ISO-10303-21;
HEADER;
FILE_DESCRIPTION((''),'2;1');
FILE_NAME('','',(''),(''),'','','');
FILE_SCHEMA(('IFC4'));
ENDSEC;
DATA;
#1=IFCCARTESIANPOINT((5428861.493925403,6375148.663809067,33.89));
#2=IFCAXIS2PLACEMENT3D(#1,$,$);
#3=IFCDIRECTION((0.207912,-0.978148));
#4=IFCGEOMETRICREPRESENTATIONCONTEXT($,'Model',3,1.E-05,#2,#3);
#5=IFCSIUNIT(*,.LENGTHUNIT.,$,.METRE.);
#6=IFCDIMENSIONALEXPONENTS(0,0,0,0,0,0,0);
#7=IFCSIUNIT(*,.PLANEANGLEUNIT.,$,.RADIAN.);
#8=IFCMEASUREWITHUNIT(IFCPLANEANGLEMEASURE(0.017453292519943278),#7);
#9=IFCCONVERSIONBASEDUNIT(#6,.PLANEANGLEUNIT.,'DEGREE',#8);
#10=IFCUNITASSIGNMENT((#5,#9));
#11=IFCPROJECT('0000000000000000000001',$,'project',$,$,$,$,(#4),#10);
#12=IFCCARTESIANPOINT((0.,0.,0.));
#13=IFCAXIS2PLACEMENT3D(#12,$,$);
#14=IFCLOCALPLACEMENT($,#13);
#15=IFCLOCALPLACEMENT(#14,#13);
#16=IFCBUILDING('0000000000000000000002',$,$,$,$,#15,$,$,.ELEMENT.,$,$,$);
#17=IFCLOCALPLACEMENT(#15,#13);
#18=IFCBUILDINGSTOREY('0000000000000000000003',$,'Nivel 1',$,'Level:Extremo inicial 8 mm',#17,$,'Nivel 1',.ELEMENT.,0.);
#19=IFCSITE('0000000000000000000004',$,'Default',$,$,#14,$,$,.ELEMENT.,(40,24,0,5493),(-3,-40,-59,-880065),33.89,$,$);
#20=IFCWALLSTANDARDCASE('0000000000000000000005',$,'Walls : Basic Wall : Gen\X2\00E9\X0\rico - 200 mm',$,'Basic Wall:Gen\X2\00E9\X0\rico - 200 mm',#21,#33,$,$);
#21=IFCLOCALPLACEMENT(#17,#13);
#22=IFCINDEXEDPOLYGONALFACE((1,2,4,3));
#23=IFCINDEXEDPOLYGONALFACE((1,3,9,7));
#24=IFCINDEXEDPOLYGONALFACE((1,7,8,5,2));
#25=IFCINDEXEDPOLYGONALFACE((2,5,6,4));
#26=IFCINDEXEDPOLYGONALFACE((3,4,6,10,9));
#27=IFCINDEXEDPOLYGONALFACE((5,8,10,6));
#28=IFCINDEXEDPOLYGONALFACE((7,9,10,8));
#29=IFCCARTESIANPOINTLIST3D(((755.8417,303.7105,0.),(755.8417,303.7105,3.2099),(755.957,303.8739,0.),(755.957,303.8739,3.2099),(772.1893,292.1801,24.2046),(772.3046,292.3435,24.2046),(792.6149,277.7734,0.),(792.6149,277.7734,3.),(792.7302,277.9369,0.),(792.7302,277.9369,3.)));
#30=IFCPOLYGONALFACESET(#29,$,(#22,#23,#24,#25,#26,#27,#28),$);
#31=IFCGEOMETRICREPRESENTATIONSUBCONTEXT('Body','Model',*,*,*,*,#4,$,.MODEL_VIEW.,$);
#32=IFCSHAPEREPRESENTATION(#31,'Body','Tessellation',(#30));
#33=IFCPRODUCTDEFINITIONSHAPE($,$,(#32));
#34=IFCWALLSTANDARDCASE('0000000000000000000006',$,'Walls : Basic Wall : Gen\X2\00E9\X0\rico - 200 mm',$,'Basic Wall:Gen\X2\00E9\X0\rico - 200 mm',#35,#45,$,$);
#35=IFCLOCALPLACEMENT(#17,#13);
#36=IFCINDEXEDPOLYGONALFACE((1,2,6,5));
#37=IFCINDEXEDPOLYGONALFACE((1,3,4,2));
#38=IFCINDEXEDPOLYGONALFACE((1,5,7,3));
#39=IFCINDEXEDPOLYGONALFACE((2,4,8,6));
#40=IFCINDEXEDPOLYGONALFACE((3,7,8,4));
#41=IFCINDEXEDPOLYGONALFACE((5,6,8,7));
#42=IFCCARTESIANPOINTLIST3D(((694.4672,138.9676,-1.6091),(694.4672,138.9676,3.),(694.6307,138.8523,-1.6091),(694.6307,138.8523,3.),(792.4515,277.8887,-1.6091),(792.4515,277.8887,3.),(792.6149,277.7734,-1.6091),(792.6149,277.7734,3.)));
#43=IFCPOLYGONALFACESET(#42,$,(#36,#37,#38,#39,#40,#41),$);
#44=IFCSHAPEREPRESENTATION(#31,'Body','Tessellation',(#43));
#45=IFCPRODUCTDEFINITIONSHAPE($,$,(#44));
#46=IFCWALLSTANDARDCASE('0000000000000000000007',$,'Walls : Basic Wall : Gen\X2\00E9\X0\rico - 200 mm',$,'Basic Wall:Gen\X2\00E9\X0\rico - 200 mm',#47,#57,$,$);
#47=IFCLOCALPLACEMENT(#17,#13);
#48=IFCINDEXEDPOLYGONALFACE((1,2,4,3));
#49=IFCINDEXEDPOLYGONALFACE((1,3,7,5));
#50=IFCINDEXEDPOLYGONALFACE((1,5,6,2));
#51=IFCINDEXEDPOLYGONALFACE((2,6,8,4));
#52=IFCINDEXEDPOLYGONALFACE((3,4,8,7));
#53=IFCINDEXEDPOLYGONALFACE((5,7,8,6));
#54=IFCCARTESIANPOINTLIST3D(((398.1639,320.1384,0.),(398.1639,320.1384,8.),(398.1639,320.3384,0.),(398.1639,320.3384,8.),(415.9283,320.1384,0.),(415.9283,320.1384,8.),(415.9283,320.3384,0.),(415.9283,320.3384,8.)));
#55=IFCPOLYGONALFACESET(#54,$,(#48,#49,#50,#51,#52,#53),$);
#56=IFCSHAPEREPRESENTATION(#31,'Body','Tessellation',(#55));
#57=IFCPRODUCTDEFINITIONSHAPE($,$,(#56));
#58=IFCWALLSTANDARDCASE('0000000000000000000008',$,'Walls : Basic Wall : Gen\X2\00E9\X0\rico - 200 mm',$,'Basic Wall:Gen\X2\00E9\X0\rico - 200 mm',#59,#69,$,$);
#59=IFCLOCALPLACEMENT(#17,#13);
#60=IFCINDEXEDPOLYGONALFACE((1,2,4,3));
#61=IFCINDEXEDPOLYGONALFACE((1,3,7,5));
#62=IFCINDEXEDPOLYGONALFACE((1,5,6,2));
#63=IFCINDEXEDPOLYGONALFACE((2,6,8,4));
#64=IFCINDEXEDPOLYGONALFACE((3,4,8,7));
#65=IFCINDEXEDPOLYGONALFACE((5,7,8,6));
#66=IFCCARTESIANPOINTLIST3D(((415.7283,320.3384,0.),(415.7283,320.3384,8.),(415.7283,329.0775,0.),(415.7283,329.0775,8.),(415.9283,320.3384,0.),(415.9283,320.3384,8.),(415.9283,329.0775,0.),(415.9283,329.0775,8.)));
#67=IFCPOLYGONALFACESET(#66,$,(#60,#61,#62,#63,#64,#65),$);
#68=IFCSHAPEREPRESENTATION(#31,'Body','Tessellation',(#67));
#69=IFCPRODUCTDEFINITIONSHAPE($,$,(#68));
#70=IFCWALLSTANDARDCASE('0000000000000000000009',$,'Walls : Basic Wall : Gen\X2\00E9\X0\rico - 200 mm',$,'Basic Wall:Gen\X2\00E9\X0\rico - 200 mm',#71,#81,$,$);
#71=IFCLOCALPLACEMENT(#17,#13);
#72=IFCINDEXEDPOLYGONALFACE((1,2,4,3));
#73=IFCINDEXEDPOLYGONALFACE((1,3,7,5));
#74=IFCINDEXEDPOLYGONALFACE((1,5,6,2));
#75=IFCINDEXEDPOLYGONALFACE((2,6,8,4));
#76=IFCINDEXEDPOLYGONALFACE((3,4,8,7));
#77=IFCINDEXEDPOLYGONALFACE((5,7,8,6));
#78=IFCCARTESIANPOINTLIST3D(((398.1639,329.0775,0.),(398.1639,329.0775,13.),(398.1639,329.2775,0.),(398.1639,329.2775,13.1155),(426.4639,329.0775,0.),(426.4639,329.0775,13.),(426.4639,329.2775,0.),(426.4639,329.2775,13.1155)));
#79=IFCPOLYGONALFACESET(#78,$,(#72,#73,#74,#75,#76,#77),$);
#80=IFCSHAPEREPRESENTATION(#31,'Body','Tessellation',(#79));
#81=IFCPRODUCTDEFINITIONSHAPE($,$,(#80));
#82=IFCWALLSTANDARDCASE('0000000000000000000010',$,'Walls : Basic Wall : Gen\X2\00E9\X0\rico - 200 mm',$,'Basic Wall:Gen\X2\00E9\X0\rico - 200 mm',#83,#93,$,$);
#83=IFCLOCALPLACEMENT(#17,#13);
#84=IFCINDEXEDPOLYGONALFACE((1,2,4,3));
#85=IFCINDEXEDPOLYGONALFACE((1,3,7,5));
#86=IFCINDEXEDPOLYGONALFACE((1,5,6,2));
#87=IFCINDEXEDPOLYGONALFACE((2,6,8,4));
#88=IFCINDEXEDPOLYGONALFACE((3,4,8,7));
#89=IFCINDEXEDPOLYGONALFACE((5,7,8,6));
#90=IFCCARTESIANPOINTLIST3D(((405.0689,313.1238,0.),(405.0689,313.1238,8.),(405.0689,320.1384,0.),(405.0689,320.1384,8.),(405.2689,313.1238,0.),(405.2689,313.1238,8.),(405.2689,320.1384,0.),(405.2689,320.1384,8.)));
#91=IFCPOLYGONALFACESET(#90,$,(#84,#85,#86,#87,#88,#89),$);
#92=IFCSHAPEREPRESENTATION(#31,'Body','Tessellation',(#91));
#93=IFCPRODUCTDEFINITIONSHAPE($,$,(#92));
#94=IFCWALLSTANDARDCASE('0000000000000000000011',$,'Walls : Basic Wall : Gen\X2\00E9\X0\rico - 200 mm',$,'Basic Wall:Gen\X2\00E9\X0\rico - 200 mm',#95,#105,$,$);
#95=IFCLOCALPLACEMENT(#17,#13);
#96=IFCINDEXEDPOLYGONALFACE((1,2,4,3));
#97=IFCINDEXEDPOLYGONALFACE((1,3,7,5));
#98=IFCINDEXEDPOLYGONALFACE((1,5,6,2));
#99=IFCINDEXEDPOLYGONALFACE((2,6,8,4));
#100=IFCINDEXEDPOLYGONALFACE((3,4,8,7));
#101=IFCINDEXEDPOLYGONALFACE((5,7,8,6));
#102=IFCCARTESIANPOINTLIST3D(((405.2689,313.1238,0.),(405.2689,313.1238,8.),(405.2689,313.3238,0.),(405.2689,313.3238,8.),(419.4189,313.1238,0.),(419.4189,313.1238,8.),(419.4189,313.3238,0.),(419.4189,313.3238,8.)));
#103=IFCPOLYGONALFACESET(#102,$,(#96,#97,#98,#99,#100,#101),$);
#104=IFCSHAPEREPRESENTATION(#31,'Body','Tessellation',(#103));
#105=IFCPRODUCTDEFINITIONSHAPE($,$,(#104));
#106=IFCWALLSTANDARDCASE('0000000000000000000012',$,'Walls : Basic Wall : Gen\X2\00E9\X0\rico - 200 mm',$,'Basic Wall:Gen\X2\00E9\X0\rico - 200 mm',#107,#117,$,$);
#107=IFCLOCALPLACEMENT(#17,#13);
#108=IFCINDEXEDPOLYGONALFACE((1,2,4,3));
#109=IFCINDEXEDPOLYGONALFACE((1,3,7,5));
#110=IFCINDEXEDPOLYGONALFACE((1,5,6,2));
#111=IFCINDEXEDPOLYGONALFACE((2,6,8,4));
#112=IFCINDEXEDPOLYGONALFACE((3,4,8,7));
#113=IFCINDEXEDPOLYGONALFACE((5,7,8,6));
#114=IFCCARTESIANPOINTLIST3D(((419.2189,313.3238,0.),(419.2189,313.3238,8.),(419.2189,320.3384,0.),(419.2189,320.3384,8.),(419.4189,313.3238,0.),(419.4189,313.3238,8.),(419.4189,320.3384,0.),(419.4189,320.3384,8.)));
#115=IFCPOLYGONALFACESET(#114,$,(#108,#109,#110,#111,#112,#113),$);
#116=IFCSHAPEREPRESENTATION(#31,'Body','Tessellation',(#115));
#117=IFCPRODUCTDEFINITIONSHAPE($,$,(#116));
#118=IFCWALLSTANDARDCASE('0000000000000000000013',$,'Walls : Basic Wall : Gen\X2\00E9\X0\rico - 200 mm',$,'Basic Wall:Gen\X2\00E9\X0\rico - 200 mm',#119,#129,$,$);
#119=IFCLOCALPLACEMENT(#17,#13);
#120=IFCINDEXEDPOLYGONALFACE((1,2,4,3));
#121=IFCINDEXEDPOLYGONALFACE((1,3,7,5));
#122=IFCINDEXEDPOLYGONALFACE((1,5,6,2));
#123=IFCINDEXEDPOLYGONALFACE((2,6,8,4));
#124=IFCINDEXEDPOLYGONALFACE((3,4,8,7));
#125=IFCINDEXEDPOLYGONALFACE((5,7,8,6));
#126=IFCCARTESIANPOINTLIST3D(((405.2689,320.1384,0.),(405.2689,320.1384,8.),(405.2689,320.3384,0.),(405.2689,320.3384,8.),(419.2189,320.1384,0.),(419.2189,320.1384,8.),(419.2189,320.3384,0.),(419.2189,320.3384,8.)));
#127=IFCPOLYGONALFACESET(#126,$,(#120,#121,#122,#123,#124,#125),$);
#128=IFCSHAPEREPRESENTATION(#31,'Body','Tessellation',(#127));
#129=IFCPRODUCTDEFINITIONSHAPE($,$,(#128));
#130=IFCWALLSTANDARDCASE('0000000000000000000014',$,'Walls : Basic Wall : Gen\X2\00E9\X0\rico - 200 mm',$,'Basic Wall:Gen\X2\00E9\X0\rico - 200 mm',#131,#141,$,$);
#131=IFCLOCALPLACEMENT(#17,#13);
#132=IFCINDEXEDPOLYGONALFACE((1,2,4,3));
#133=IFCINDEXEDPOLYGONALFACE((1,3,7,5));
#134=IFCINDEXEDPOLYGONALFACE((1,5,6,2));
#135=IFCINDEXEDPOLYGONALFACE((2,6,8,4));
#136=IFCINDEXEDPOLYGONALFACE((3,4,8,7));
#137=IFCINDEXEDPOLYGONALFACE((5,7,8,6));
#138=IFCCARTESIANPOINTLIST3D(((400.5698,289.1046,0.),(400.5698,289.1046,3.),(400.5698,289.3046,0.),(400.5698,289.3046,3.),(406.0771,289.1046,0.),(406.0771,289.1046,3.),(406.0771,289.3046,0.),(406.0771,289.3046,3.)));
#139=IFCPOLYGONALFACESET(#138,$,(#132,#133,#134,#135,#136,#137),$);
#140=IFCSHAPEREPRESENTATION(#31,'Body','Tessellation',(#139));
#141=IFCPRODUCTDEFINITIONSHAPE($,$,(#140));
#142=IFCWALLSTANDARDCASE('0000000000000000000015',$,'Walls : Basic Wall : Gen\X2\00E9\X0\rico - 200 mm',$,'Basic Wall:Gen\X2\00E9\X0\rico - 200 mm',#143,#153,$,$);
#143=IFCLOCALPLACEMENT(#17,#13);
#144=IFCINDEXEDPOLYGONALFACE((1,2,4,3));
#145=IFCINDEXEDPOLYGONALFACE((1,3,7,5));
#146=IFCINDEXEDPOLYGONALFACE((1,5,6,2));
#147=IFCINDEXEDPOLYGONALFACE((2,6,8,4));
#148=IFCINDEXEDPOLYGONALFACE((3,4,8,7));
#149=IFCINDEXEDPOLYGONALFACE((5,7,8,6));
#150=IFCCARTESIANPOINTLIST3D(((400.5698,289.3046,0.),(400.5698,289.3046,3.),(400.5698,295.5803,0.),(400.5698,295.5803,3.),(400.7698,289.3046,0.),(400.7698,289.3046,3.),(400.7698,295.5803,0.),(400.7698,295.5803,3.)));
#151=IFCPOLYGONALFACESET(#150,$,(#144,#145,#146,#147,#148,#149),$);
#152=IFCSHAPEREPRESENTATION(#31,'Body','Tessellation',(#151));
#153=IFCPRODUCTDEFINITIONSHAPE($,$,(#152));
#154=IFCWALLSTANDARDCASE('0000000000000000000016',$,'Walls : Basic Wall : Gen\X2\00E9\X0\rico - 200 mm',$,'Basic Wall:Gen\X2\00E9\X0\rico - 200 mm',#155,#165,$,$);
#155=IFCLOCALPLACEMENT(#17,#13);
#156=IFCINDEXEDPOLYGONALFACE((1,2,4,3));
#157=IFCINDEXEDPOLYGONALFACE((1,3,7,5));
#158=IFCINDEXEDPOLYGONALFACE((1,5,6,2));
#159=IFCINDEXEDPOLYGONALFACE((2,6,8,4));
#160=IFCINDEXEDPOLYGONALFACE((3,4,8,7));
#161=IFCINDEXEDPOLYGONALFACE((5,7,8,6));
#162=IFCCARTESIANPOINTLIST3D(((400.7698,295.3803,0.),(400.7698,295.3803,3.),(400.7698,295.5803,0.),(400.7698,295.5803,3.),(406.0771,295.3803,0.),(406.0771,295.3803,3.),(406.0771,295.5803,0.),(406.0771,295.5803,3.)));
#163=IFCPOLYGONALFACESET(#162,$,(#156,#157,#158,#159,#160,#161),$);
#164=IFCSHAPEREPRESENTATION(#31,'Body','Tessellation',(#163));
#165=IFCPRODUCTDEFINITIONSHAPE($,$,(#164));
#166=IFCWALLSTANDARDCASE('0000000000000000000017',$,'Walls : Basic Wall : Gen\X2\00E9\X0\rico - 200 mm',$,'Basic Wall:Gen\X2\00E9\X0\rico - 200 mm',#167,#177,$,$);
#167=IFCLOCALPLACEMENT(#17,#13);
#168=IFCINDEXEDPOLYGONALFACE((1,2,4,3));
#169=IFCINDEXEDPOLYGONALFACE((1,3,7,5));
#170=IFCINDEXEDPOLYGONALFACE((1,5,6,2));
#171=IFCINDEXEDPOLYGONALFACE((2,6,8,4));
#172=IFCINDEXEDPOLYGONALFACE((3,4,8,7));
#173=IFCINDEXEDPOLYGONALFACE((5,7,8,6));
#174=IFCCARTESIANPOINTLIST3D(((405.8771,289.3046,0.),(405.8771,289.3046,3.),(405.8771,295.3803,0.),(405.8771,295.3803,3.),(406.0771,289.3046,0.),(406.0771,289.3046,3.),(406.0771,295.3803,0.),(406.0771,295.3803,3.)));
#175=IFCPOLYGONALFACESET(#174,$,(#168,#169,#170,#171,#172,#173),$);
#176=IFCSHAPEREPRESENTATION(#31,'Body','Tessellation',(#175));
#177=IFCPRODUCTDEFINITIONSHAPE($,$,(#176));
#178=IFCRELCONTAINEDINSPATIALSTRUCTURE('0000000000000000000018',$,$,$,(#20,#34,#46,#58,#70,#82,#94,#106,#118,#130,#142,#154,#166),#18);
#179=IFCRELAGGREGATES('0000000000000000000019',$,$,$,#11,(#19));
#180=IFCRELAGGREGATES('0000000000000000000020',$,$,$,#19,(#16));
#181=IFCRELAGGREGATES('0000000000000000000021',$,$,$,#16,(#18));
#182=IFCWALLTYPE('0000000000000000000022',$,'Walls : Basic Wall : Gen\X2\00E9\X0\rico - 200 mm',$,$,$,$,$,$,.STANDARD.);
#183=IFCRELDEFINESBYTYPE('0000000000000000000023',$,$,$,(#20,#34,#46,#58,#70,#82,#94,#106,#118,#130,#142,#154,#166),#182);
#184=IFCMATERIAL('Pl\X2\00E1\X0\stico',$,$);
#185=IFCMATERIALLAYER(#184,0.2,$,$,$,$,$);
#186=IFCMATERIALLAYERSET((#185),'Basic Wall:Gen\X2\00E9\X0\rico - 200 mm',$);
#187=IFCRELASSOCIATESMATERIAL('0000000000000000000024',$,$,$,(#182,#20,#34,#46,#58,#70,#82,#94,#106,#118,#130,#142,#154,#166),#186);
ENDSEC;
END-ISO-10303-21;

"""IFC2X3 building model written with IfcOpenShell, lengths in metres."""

from ifc_helpers import new_model, entity, si_unit, converted_unit, direction, frame, frame_2d, origin, place, context, subcontext, project, spatial, polyline, rectangle, extrude, clip, bounded_halfspace, material, layer, layer_set, layer_usage, type_object, element, save


model = new_model("IFC2X3")

# Units and contexts
model_context = context("Model", 3, precision=1e-05, world=frame((5428861.493925403, 6375148.663809067, 33.89)), true_north=direction((0.207912, -0.978148)))
body_context = subcontext(model_context, "Body", "Model", "MODEL_VIEW")
ifc_project = project(units=[si_unit("LENGTHUNIT", "METRE"), converted_unit("PLANEANGLEUNIT", "DEGREE", entity("IfcPlaneAngleMeasure", 0.017453292519943278), si_unit("PLANEANGLEUNIT", "RADIAN"), dimensions=[0, 0, 0, 0, 0, 0, 0])], contexts=[model_context])

# Site, building, storey
site_placement = place(None, origin())
site = spatial("IfcSite", under=ifc_project, at=site_placement, Name="Default", CompositionType="ELEMENT", RefLatitude=(40, 24, 0, 5493), RefLongitude=(-3, -40, -59, -880065), RefElevation=33.89)
building_placement = place(site_placement, origin())
building = spatial("IfcBuilding", under=site, at=building_placement, CompositionType="ELEMENT")
storey_placement = place(building_placement, origin())
storey = spatial("IfcBuildingStorey", under=building, at=storey_placement, Name="Nivel 1", ObjectType="Level:Extremo inicial 8 mm", LongName="Nivel 1", CompositionType="ELEMENT", Elevation=0.0)

# Walls
ifc_material = material(Name="Plástico")
ifc_layer = layer(ifc_material, 0.2)
ifc_layer_set = layer_set([ifc_layer], Name="Basic Wall:Genérico - 200 mm")
ifc_layer_usage_1 = layer_usage(ifc_layer_set, "AXIS2", "NEGATIVE", 0.1)
wall_type = type_object("IfcWallType", Name="Walls : Basic Wall : Genérico - 200 mm", PredefinedType="STANDARD", material=ifc_layer_set)
wall_1_placement = place(storey_placement, frame((755.8993, 303.7922, 0.0), z_axis=(0.0, 0.0, 1.0), x_axis=(0.817183, -0.576378, 0.0)))
element("IfcWallStandardCase", 1, at=wall_1_placement, inside=storey, type_object=wall_type, material=ifc_layer_usage_1, Name="Walls : Basic Wall : Genérico - 200 mm", ObjectType="Basic Wall:Genérico - 200 mm", context=body_context, shape_type="Clipping", body=[
    clip(clip(extrude(rectangle(XDim=45.0, YDim=0.2, at=frame_2d((22.5, 0.0), x_axis=(-1.0, 0.0))), origin(), (0.0, 0.0, 1.0), 24.2046), bounded_halfspace(frame((20.0049, -0.1, 24.2046), z_axis=(0.646917, 0.0, 0.76256), x_axis=(0.0, 1.0, 0.0)), False, frame((20.0049, -0.1, 24.2046)), polyline([(0.0, 0.0), (24.9951, 0.0), (24.9951, 0.2), (0.0, 0.2), (0.0, 0.0)]))), bounded_halfspace(frame((0.0, -0.1, 3.2099), z_axis=(-0.723966, 0.0, 0.689835), x_axis=(0.0, -1.0, 0.0)), False, frame((0.0, -0.1, 3.2099)), polyline([(0.0, 0.0), (20.0049, 0.0), (20.0049, 0.2), (0.0, 0.2), (0.0, 0.0)]))),
])
ifc_layer_usage_2 = layer_usage(ifc_layer_set, "AXIS2", "NEGATIVE", 0.1)
wall_2_placement = place(storey_placement, frame((792.5332, 277.8311, -1.6091), z_axis=(0.0, 0.0, 1.0), x_axis=(-0.576378, -0.817183, 0.0)))
element("IfcWallStandardCase", 2, at=wall_2_placement, inside=storey, type_object=wall_type, material=ifc_layer_usage_2, Name="Walls : Basic Wall : Genérico - 200 mm", ObjectType="Basic Wall:Genérico - 200 mm", context=body_context, shape_type="SweptSolid", body=[
    extrude(rectangle(XDim=170.0, YDim=0.2, at=frame_2d((85.0, 0.0), x_axis=(-1.0, 0.0))), origin(), (0.0, 0.0, 1.0), 4.6091),
])
ifc_layer_usage_3 = layer_usage(ifc_layer_set, "AXIS2", "NEGATIVE", 0.1)
wall_3_placement = place(storey_placement, frame((398.1639, 320.2384, 0.0)))
element("IfcWallStandardCase", 3, at=wall_3_placement, inside=storey, type_object=wall_type, material=ifc_layer_usage_3, Name="Walls : Basic Wall : Genérico - 200 mm", ObjectType="Basic Wall:Genérico - 200 mm", context=body_context, shape_type="SweptSolid", body=[
    extrude(rectangle(XDim=17.7644, YDim=0.2, at=frame_2d((8.8822, 0.0), x_axis=(-1.0, 0.0))), origin(), (0.0, 0.0, 1.0), 8.0),
])
ifc_layer_usage_4 = layer_usage(ifc_layer_set, "AXIS2", "NEGATIVE", 0.1)
wall_4_placement = place(storey_placement, frame((415.8283, 320.3384, 0.0), z_axis=(0.0, 0.0, 1.0), x_axis=(0.0, 1.0, 0.0)))
element("IfcWallStandardCase", 4, at=wall_4_placement, inside=storey, type_object=wall_type, material=ifc_layer_usage_4, Name="Walls : Basic Wall : Genérico - 200 mm", ObjectType="Basic Wall:Genérico - 200 mm", context=body_context, shape_type="SweptSolid", body=[
    extrude(rectangle(XDim=8.7391, YDim=0.2, at=frame_2d((4.3695, 0.0), x_axis=(-1.0, 0.0))), origin(), (0.0, 0.0, 1.0), 8.0),
])
ifc_layer_usage_5 = layer_usage(ifc_layer_set, "AXIS2", "NEGATIVE", 0.1)
wall_5_placement = place(storey_placement, frame((426.4639, 329.1775, 0.0), z_axis=(0.0, 0.0, 1.0), x_axis=(-1.0, 0.0, 0.0)))
element("IfcWallStandardCase", 5, at=wall_5_placement, inside=storey, type_object=wall_type, material=ifc_layer_usage_5, Name="Walls : Basic Wall : Genérico - 200 mm", ObjectType="Basic Wall:Genérico - 200 mm", context=body_context, shape_type="Clipping", body=[
    clip(extrude(rectangle(XDim=28.3, YDim=0.2, at=frame_2d((14.15, 0.0), x_axis=(-1.0, 0.0))), origin(), (0.0, 0.0, 1.0), 13.1155), bounded_halfspace(frame((0.0, -0.1, 13.1155), z_axis=(0.0, 0.5, 0.866025), x_axis=(-1.0, 0.0, 0.0)), False, frame((0.0, -0.1, 13.1155)), polyline([(0.0, 0.0), (28.3, 0.0), (28.3, 0.2), (0.0, 0.2), (0.0, 0.0)]))),
])
ifc_layer_usage_6 = layer_usage(ifc_layer_set, "AXIS2", "NEGATIVE", 0.1)
wall_6_placement = place(storey_placement, frame((405.1689, 320.1384, 0.0), z_axis=(0.0, 0.0, 1.0), x_axis=(0.0, -1.0, 0.0)))
element("IfcWallStandardCase", 6, at=wall_6_placement, inside=storey, type_object=wall_type, material=ifc_layer_usage_6, Name="Walls : Basic Wall : Genérico - 200 mm", ObjectType="Basic Wall:Genérico - 200 mm", context=body_context, shape_type="SweptSolid", body=[
    extrude(rectangle(XDim=7.0146, YDim=0.2, at=frame_2d((3.5073, 0.0), x_axis=(-1.0, 0.0))), origin(), (0.0, 0.0, 1.0), 8.0),
])
ifc_layer_usage_7 = layer_usage(ifc_layer_set, "AXIS2", "NEGATIVE", 0.1)
wall_7_placement = place(storey_placement, frame((405.2689, 313.2238, 0.0)))
element("IfcWallStandardCase", 7, at=wall_7_placement, inside=storey, type_object=wall_type, material=ifc_layer_usage_7, Name="Walls : Basic Wall : Genérico - 200 mm", ObjectType="Basic Wall:Genérico - 200 mm", context=body_context, shape_type="SweptSolid", body=[
    extrude(rectangle(XDim=14.15, YDim=0.2, at=frame_2d((7.075, 0.0), x_axis=(-1.0, 0.0))), origin(), (0.0, 0.0, 1.0), 8.0),
])
ifc_layer_usage_8 = layer_usage(ifc_layer_set, "AXIS2", "NEGATIVE", 0.1)
wall_8_placement = place(storey_placement, frame((419.3189, 313.3238, 0.0), z_axis=(0.0, 0.0, 1.0), x_axis=(0.0, 1.0, 0.0)))
element("IfcWallStandardCase", 8, at=wall_8_placement, inside=storey, type_object=wall_type, material=ifc_layer_usage_8, Name="Walls : Basic Wall : Genérico - 200 mm", ObjectType="Basic Wall:Genérico - 200 mm", context=body_context, shape_type="SweptSolid", body=[
    extrude(rectangle(XDim=7.0146, YDim=0.2, at=frame_2d((3.5073, 0.0), x_axis=(-1.0, 0.0))), origin(), (0.0, 0.0, 1.0), 8.0),
])
ifc_layer_usage_9 = layer_usage(ifc_layer_set, "AXIS2", "NEGATIVE", 0.1)
wall_9_placement = place(storey_placement, frame((419.2189, 320.2384, 0.0), z_axis=(0.0, 0.0, 1.0), x_axis=(-1.0, 0.0, 0.0)))
element("IfcWallStandardCase", 9, at=wall_9_placement, inside=storey, type_object=wall_type, material=ifc_layer_usage_9, Name="Walls : Basic Wall : Genérico - 200 mm", ObjectType="Basic Wall:Genérico - 200 mm", context=body_context, shape_type="SweptSolid", body=[
    extrude(rectangle(XDim=13.95, YDim=0.2, at=frame_2d((6.975, 0.0), x_axis=(-1.0, 0.0))), origin(), (0.0, 0.0, 1.0), 8.0),
])
ifc_layer_usage_10 = layer_usage(ifc_layer_set, "AXIS2", "NEGATIVE", 0.1)
wall_10_placement = place(storey_placement, frame((406.0771, 289.2046, 0.0), z_axis=(0.0, 0.0, 1.0), x_axis=(-1.0, 0.0, 0.0)))
element("IfcWallStandardCase", 10, at=wall_10_placement, inside=storey, type_object=wall_type, material=ifc_layer_usage_10, Name="Walls : Basic Wall : Genérico - 200 mm", ObjectType="Basic Wall:Genérico - 200 mm", context=body_context, shape_type="SweptSolid", body=[
    extrude(rectangle(XDim=5.5074, YDim=0.2, at=frame_2d((2.7537, 0.0), x_axis=(-1.0, 0.0))), origin(), (0.0, 0.0, 1.0), 3.0),
])
ifc_layer_usage_11 = layer_usage(ifc_layer_set, "AXIS2", "NEGATIVE", 0.1)
wall_11_placement = place(storey_placement, frame((400.6698, 289.3046, 0.0), z_axis=(0.0, 0.0, 1.0), x_axis=(0.0, 1.0, 0.0)))
element("IfcWallStandardCase", 11, at=wall_11_placement, inside=storey, type_object=wall_type, material=ifc_layer_usage_11, Name="Walls : Basic Wall : Genérico - 200 mm", ObjectType="Basic Wall:Genérico - 200 mm", context=body_context, shape_type="SweptSolid", body=[
    extrude(rectangle(XDim=6.2756, YDim=0.2, at=frame_2d((3.1378, 0.0), x_axis=(-1.0, 0.0))), origin(), (0.0, 0.0, 1.0), 3.0),
])
ifc_layer_usage_12 = layer_usage(ifc_layer_set, "AXIS2", "NEGATIVE", 0.1)
wall_12_placement = place(storey_placement, frame((400.7698, 295.4803, 0.0)))
element("IfcWallStandardCase", 12, at=wall_12_placement, inside=storey, type_object=wall_type, material=ifc_layer_usage_12, Name="Walls : Basic Wall : Genérico - 200 mm", ObjectType="Basic Wall:Genérico - 200 mm", context=body_context, shape_type="SweptSolid", body=[
    extrude(rectangle(XDim=5.3074, YDim=0.2, at=frame_2d((2.6537, 0.0), x_axis=(-1.0, 0.0))), origin(), (0.0, 0.0, 1.0), 3.0),
])
ifc_layer_usage_13 = layer_usage(ifc_layer_set, "AXIS2", "NEGATIVE", 0.1)
wall_13_placement = place(storey_placement, frame((405.9771, 295.3803, 0.0), z_axis=(0.0, 0.0, 1.0), x_axis=(0.0, -1.0, 0.0)))
element("IfcWallStandardCase", 13, at=wall_13_placement, inside=storey, type_object=wall_type, material=ifc_layer_usage_13, Name="Walls : Basic Wall : Genérico - 200 mm", ObjectType="Basic Wall:Genérico - 200 mm", context=body_context, shape_type="SweptSolid", body=[
    extrude(rectangle(XDim=6.0756, YDim=0.2, at=frame_2d((3.0378, 0.0), x_axis=(-1.0, 0.0))), origin(), (0.0, 0.0, 1.0), 3.0),
])

save(model, "model.ifc")
